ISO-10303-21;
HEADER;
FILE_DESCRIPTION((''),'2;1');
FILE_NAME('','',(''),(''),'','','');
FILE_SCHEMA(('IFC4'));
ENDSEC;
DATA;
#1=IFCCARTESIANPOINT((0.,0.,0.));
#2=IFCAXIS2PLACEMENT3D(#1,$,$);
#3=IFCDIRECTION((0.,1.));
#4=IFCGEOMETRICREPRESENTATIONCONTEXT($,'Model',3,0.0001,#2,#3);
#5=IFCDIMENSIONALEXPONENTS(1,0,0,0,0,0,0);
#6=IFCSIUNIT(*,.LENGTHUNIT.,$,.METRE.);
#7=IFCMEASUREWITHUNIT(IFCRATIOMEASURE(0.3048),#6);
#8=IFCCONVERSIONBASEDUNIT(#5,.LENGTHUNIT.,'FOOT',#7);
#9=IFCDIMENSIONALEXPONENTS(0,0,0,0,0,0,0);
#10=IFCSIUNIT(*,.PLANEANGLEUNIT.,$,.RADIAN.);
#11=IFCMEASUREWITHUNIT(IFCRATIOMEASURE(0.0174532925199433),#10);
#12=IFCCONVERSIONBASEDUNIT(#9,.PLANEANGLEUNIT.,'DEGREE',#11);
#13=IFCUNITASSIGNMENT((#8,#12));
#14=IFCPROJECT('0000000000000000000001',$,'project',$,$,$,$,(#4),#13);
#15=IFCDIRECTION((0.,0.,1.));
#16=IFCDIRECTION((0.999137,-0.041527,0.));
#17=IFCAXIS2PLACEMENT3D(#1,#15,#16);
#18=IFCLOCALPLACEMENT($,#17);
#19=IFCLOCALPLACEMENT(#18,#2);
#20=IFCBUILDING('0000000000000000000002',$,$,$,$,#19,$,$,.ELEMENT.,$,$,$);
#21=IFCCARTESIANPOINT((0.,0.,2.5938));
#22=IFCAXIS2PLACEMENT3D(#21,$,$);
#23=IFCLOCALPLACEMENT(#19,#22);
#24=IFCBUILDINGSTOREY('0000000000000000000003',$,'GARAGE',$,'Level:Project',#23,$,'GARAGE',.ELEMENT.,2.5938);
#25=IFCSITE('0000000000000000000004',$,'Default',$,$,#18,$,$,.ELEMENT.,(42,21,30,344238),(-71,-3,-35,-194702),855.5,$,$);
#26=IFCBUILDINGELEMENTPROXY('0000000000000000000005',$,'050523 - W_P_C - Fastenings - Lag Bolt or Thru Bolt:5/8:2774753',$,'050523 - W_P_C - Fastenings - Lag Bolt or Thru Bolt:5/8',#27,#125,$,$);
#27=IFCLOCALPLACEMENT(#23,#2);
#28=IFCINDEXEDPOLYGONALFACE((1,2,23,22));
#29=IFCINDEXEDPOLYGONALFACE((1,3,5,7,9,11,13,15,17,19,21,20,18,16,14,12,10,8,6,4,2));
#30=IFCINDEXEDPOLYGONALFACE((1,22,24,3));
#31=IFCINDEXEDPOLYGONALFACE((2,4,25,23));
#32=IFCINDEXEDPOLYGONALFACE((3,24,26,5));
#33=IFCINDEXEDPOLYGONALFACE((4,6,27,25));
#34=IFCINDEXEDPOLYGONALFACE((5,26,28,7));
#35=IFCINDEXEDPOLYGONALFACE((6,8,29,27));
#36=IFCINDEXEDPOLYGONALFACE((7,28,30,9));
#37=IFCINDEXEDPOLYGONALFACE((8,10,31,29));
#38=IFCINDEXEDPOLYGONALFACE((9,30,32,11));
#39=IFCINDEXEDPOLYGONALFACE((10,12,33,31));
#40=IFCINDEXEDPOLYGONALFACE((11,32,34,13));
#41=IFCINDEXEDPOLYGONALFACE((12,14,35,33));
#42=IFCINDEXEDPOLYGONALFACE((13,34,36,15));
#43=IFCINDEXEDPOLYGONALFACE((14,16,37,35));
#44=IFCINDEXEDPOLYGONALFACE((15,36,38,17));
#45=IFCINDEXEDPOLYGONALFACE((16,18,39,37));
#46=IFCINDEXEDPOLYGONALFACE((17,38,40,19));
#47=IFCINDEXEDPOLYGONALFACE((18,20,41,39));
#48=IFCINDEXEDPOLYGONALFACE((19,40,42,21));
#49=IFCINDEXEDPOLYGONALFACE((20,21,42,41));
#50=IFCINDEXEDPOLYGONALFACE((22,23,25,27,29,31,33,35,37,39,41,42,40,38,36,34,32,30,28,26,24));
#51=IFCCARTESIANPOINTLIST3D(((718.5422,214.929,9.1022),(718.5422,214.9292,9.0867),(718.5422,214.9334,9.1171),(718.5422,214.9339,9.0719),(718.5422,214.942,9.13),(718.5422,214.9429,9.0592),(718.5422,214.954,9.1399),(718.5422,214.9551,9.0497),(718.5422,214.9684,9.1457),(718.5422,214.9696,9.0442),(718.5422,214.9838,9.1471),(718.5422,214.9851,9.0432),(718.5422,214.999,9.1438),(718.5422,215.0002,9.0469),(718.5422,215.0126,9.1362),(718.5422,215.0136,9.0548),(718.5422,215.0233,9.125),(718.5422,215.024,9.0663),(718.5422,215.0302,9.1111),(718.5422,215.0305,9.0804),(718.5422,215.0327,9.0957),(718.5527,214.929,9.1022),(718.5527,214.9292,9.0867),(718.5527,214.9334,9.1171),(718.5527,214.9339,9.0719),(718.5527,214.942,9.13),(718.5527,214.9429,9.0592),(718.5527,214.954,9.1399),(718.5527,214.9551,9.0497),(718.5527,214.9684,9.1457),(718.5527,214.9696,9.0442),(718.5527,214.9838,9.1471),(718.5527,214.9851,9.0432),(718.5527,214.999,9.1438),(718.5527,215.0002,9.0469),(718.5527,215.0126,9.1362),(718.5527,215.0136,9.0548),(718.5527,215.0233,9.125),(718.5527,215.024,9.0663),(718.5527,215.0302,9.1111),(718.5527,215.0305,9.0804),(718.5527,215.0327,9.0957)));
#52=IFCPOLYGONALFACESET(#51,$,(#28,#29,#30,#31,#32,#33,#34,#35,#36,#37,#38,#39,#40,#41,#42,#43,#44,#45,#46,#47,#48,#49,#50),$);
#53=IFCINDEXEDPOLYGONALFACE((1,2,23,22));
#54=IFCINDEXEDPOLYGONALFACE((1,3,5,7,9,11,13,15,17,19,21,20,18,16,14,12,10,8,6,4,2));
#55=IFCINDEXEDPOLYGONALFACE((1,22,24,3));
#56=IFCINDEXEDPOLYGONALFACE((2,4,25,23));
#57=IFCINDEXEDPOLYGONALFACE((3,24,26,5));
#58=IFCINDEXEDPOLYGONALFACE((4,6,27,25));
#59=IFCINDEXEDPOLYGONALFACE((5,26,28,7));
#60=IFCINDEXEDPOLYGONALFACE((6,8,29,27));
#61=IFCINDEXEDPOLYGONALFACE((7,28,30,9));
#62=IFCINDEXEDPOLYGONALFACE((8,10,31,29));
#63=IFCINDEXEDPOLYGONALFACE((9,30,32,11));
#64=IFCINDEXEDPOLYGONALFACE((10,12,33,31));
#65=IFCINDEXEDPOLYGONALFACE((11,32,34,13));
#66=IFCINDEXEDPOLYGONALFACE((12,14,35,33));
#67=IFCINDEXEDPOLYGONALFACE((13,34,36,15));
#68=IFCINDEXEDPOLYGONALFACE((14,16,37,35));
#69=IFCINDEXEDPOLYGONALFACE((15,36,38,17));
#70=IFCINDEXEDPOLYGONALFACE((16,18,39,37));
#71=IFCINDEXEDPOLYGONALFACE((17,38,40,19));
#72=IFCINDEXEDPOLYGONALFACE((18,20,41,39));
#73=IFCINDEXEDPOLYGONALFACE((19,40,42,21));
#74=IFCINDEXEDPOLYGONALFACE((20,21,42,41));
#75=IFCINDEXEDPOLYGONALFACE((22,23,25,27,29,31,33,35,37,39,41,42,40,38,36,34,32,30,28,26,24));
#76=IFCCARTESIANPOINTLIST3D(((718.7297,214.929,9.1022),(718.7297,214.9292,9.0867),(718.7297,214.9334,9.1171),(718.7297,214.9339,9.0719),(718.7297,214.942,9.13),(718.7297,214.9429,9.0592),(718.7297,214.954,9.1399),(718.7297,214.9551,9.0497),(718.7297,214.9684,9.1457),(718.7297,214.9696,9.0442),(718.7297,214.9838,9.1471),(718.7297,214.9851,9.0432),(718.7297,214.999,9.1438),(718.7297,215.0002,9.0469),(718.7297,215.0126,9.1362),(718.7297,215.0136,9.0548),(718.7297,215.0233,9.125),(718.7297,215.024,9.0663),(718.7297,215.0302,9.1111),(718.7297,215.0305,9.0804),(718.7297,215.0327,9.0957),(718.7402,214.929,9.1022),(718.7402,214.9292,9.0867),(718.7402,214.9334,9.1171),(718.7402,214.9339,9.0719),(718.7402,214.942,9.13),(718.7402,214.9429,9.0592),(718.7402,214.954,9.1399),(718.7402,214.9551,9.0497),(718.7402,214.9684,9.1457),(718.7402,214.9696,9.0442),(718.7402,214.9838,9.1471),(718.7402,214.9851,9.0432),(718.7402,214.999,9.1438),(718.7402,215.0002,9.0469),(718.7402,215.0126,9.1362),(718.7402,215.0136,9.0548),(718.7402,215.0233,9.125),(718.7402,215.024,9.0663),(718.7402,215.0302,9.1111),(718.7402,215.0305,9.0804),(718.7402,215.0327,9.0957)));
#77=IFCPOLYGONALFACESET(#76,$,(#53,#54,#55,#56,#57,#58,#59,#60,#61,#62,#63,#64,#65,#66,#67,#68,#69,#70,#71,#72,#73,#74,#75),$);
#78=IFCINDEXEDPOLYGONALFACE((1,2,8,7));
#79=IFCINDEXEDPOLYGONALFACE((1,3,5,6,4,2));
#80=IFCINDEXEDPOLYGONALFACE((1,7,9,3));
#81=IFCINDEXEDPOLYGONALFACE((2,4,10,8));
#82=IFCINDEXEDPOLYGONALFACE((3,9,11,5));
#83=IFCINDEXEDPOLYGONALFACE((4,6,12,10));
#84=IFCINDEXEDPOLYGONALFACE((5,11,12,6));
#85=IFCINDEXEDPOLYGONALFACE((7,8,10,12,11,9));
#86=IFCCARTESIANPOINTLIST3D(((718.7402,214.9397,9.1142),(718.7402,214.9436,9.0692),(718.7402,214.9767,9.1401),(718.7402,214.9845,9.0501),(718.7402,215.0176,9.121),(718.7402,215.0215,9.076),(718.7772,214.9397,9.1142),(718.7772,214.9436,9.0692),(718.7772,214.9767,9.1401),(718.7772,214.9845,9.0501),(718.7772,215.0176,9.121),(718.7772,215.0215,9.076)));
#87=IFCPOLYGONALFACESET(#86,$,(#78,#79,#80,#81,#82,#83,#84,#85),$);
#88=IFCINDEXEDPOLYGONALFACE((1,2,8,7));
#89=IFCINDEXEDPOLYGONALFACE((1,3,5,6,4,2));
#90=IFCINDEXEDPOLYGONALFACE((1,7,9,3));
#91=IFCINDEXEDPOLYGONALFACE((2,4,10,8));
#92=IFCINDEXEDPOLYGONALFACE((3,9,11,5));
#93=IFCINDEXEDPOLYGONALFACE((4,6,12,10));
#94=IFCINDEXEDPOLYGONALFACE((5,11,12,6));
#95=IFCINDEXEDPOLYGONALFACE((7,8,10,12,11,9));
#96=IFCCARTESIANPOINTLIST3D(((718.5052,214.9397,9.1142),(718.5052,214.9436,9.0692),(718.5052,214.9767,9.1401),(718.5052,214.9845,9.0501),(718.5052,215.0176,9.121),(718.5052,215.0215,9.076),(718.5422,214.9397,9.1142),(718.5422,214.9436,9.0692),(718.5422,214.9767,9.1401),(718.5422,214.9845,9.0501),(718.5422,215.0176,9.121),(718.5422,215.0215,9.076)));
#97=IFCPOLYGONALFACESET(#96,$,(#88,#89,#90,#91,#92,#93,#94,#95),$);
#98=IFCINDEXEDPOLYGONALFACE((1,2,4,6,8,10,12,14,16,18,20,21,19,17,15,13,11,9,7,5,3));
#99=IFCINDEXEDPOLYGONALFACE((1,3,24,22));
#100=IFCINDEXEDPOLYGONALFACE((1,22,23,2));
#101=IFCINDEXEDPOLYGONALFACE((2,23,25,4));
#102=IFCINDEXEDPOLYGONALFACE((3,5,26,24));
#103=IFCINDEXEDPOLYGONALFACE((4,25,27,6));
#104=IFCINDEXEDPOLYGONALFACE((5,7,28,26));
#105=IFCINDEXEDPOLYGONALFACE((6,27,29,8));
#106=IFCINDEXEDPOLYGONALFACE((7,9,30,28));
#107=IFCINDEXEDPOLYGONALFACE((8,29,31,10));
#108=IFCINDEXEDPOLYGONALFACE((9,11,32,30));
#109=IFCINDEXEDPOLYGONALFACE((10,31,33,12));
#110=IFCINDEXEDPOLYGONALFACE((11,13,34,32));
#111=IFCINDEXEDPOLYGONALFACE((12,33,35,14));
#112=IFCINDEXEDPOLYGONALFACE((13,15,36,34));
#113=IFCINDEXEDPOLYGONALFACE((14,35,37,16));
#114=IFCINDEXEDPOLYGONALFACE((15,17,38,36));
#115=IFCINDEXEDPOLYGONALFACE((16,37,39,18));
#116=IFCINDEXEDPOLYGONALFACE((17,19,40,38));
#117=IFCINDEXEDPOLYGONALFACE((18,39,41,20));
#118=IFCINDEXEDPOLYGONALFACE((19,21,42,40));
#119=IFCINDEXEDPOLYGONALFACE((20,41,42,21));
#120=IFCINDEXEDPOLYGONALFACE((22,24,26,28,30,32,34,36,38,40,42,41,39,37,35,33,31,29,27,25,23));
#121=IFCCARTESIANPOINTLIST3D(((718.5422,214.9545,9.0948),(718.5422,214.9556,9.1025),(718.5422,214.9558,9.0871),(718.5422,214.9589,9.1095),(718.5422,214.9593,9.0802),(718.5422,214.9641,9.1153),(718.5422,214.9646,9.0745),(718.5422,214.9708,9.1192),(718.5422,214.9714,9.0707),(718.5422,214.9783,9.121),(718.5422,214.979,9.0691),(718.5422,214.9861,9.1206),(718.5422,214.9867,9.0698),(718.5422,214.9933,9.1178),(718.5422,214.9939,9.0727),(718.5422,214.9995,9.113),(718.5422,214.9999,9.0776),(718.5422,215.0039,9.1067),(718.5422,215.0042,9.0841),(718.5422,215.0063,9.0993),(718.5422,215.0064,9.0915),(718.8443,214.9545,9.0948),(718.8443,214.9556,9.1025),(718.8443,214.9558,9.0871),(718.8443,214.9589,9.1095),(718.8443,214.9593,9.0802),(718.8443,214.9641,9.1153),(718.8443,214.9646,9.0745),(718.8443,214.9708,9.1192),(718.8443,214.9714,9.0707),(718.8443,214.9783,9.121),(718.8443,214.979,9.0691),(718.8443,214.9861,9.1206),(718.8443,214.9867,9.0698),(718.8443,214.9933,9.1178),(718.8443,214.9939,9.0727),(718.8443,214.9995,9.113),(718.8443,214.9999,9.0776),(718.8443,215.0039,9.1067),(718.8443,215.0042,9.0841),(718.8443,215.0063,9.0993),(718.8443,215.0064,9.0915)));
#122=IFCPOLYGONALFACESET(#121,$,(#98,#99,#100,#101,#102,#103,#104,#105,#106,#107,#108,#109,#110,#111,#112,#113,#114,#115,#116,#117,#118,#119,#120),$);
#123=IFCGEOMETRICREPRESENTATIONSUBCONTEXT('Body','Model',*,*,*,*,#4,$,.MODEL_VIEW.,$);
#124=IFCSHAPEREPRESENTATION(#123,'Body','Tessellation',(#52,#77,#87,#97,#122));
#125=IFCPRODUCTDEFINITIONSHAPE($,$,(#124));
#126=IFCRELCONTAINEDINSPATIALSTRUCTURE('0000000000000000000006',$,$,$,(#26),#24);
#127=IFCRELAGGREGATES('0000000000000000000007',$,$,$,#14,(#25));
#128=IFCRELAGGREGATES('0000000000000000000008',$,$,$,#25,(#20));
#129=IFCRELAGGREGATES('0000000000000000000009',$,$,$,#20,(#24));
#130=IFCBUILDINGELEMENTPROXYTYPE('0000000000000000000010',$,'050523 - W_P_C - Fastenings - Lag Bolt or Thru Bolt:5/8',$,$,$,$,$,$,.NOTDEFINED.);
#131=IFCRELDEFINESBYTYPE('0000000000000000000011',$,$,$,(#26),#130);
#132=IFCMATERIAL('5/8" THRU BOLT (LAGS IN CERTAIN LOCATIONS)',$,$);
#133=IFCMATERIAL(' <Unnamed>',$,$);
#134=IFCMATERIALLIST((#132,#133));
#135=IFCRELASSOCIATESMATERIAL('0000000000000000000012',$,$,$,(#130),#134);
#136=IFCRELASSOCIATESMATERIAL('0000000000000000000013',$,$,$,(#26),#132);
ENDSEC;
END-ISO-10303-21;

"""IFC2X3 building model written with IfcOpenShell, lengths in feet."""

from ifc_helpers import new_model, entity, si_unit, converted_unit, direction, frame, frame_2d, origin, place, context, subcontext, project, spatial, polyline, circle, outline, extrude, source, transform, mapped, material, material_list, type_object, type_shapes, element, save


model = new_model("IFC2X3")

# Units and contexts
model_context = context("Model", 3, precision=0.0001, world=origin(), true_north=direction((0.0, 1.0)))
body_context = subcontext(model_context, "Body", "Model", "MODEL_VIEW")
ifc_project = project(units=[converted_unit("LENGTHUNIT", "FOOT", entity("IfcRatioMeasure", 0.3048), si_unit("LENGTHUNIT", "METRE"), dimensions=[1, 0, 0, 0, 0, 0, 0]), converted_unit("PLANEANGLEUNIT", "DEGREE", entity("IfcRatioMeasure", 0.0174532925199433), si_unit("PLANEANGLEUNIT", "RADIAN"), dimensions=[0, 0, 0, 0, 0, 0, 0])], contexts=[model_context])

# Site, building, storey
site_placement = place(None, frame((0.0, 0.0, 0.0), z_axis=(0.0, 0.0, 1.0), x_axis=(0.999137, -0.041527, 0.0)))
site = spatial("IfcSite", under=ifc_project, at=site_placement, Name="Default", CompositionType="ELEMENT", RefLatitude=(42, 21, 30, 344238), RefLongitude=(-71, -3, -35, -194702), RefElevation=855.5)
building_placement = place(site_placement, origin())
building = spatial("IfcBuilding", under=site, at=building_placement, CompositionType="ELEMENT")
storey_placement = place(building_placement, frame((0.0, 0.0, 2.5938)))
storey = spatial("IfcBuildingStorey", under=building, at=storey_placement, Name="GARAGE", ObjectType="Level:Project", LongName="GARAGE", CompositionType="ELEMENT", Elevation=2.5938)

# Building element proxy
ifc_material_1 = material(Name="5/8\" THRU BOLT (LAGS IN CERTAIN LOCATIONS)")
ifc_material_2 = material(Name=" <Unnamed>")
ifc_material_list_1 = material_list([ifc_material_1, ifc_material_2])
building_element_proxy_type_1 = type_object("IfcBuildingElementProxyType", Name="050523 - W_P_C - Fastenings - Lag Bolt or Thru Bolt:5/8", PredefinedType="NOTDEFINED", material=ifc_material_list_1)
shared_shape_1 = source(origin(), body_context, "Body", "SweptSolid", [
    extrude(circle(Radius=0.0521, at=frame_2d((0.0, 0.0), x_axis=(1.0, 0.0))), frame((0.0, 0.0, 0.0), z_axis=(0.0, 0.0, 1.0), x_axis=(0.0, -1.0, 0.0)), (0.0, 0.0, 1.0), 0.0104),
    extrude(circle(Radius=0.0521, at=frame_2d((0.0, 0.0), x_axis=(1.0, 0.0))), frame((0.0, 0.0, -0.1875), z_axis=(0.0, 0.0, 1.0), x_axis=(0.0, -1.0, 0.0)), (0.0, 0.0, 1.0), 0.0104),
    extrude(outline(polyline([(-0.0226, -0.0391), (0.0226, -0.0391), (0.0451, 0.0), (0.0226, 0.0391), (-0.0226, 0.0391), (-0.0451, 0.0), (-0.0226, -0.0391)])), frame((0.0, 0.0, -0.2245), z_axis=(0.0, 0.0, 1.0), x_axis=(0.866025, -0.5, 0.0)), (0.0, 0.0, 1.0), 0.037),
    extrude(outline(polyline([(-0.0226, -0.0391), (0.0226, -0.0391), (0.0451, 0.0), (0.0226, 0.0391), (-0.0226, 0.0391), (-0.0451, 0.0), (-0.0226, -0.0391)])), frame((0.0, 0.0, 0.0104), z_axis=(0.0, 0.0, 1.0), x_axis=(0.0, -1.0, 0.0)), (0.0, 0.0, 1.0), 0.037),
    extrude(circle(Radius=0.026, at=frame_2d((0.0, 0.0), x_axis=(1.0, 0.0))), frame((0.0, 0.0, -0.2917), z_axis=(0.0, 0.0, 1.0), x_axis=(0.0, 1.0, 0.0)), (0.0, 0.0, 1.0), 0.3021),
])
type_shapes(building_element_proxy_type_1, [shared_shape_1])
for number, where, z_axis, x_axis, name in (
    (1, (718.5527, 214.9806, 9.0951), (-1.0, 0.0, 0.0), (0.0, -0.996195, -0.087156), "050523 - W_P_C - Fastenings - Lag Bolt or Thru Bolt:5/8:2774753"),
):
    element("IfcBuildingElementProxy", number, at=place(storey_placement, frame(where, z_axis=z_axis, x_axis=x_axis)), inside=storey, type_object=building_element_proxy_type_1, material=ifc_material_1, Name=name, ObjectType="050523 - W_P_C - Fastenings - Lag Bolt or Thru Bolt:5/8", context=body_context, shape_type="MappedRepresentation", body=[
        mapped(shared_shape_1, transform((0.0, 0.0, 0.0), scale=1.0)),
    ])

save(model, "model.ifc")
